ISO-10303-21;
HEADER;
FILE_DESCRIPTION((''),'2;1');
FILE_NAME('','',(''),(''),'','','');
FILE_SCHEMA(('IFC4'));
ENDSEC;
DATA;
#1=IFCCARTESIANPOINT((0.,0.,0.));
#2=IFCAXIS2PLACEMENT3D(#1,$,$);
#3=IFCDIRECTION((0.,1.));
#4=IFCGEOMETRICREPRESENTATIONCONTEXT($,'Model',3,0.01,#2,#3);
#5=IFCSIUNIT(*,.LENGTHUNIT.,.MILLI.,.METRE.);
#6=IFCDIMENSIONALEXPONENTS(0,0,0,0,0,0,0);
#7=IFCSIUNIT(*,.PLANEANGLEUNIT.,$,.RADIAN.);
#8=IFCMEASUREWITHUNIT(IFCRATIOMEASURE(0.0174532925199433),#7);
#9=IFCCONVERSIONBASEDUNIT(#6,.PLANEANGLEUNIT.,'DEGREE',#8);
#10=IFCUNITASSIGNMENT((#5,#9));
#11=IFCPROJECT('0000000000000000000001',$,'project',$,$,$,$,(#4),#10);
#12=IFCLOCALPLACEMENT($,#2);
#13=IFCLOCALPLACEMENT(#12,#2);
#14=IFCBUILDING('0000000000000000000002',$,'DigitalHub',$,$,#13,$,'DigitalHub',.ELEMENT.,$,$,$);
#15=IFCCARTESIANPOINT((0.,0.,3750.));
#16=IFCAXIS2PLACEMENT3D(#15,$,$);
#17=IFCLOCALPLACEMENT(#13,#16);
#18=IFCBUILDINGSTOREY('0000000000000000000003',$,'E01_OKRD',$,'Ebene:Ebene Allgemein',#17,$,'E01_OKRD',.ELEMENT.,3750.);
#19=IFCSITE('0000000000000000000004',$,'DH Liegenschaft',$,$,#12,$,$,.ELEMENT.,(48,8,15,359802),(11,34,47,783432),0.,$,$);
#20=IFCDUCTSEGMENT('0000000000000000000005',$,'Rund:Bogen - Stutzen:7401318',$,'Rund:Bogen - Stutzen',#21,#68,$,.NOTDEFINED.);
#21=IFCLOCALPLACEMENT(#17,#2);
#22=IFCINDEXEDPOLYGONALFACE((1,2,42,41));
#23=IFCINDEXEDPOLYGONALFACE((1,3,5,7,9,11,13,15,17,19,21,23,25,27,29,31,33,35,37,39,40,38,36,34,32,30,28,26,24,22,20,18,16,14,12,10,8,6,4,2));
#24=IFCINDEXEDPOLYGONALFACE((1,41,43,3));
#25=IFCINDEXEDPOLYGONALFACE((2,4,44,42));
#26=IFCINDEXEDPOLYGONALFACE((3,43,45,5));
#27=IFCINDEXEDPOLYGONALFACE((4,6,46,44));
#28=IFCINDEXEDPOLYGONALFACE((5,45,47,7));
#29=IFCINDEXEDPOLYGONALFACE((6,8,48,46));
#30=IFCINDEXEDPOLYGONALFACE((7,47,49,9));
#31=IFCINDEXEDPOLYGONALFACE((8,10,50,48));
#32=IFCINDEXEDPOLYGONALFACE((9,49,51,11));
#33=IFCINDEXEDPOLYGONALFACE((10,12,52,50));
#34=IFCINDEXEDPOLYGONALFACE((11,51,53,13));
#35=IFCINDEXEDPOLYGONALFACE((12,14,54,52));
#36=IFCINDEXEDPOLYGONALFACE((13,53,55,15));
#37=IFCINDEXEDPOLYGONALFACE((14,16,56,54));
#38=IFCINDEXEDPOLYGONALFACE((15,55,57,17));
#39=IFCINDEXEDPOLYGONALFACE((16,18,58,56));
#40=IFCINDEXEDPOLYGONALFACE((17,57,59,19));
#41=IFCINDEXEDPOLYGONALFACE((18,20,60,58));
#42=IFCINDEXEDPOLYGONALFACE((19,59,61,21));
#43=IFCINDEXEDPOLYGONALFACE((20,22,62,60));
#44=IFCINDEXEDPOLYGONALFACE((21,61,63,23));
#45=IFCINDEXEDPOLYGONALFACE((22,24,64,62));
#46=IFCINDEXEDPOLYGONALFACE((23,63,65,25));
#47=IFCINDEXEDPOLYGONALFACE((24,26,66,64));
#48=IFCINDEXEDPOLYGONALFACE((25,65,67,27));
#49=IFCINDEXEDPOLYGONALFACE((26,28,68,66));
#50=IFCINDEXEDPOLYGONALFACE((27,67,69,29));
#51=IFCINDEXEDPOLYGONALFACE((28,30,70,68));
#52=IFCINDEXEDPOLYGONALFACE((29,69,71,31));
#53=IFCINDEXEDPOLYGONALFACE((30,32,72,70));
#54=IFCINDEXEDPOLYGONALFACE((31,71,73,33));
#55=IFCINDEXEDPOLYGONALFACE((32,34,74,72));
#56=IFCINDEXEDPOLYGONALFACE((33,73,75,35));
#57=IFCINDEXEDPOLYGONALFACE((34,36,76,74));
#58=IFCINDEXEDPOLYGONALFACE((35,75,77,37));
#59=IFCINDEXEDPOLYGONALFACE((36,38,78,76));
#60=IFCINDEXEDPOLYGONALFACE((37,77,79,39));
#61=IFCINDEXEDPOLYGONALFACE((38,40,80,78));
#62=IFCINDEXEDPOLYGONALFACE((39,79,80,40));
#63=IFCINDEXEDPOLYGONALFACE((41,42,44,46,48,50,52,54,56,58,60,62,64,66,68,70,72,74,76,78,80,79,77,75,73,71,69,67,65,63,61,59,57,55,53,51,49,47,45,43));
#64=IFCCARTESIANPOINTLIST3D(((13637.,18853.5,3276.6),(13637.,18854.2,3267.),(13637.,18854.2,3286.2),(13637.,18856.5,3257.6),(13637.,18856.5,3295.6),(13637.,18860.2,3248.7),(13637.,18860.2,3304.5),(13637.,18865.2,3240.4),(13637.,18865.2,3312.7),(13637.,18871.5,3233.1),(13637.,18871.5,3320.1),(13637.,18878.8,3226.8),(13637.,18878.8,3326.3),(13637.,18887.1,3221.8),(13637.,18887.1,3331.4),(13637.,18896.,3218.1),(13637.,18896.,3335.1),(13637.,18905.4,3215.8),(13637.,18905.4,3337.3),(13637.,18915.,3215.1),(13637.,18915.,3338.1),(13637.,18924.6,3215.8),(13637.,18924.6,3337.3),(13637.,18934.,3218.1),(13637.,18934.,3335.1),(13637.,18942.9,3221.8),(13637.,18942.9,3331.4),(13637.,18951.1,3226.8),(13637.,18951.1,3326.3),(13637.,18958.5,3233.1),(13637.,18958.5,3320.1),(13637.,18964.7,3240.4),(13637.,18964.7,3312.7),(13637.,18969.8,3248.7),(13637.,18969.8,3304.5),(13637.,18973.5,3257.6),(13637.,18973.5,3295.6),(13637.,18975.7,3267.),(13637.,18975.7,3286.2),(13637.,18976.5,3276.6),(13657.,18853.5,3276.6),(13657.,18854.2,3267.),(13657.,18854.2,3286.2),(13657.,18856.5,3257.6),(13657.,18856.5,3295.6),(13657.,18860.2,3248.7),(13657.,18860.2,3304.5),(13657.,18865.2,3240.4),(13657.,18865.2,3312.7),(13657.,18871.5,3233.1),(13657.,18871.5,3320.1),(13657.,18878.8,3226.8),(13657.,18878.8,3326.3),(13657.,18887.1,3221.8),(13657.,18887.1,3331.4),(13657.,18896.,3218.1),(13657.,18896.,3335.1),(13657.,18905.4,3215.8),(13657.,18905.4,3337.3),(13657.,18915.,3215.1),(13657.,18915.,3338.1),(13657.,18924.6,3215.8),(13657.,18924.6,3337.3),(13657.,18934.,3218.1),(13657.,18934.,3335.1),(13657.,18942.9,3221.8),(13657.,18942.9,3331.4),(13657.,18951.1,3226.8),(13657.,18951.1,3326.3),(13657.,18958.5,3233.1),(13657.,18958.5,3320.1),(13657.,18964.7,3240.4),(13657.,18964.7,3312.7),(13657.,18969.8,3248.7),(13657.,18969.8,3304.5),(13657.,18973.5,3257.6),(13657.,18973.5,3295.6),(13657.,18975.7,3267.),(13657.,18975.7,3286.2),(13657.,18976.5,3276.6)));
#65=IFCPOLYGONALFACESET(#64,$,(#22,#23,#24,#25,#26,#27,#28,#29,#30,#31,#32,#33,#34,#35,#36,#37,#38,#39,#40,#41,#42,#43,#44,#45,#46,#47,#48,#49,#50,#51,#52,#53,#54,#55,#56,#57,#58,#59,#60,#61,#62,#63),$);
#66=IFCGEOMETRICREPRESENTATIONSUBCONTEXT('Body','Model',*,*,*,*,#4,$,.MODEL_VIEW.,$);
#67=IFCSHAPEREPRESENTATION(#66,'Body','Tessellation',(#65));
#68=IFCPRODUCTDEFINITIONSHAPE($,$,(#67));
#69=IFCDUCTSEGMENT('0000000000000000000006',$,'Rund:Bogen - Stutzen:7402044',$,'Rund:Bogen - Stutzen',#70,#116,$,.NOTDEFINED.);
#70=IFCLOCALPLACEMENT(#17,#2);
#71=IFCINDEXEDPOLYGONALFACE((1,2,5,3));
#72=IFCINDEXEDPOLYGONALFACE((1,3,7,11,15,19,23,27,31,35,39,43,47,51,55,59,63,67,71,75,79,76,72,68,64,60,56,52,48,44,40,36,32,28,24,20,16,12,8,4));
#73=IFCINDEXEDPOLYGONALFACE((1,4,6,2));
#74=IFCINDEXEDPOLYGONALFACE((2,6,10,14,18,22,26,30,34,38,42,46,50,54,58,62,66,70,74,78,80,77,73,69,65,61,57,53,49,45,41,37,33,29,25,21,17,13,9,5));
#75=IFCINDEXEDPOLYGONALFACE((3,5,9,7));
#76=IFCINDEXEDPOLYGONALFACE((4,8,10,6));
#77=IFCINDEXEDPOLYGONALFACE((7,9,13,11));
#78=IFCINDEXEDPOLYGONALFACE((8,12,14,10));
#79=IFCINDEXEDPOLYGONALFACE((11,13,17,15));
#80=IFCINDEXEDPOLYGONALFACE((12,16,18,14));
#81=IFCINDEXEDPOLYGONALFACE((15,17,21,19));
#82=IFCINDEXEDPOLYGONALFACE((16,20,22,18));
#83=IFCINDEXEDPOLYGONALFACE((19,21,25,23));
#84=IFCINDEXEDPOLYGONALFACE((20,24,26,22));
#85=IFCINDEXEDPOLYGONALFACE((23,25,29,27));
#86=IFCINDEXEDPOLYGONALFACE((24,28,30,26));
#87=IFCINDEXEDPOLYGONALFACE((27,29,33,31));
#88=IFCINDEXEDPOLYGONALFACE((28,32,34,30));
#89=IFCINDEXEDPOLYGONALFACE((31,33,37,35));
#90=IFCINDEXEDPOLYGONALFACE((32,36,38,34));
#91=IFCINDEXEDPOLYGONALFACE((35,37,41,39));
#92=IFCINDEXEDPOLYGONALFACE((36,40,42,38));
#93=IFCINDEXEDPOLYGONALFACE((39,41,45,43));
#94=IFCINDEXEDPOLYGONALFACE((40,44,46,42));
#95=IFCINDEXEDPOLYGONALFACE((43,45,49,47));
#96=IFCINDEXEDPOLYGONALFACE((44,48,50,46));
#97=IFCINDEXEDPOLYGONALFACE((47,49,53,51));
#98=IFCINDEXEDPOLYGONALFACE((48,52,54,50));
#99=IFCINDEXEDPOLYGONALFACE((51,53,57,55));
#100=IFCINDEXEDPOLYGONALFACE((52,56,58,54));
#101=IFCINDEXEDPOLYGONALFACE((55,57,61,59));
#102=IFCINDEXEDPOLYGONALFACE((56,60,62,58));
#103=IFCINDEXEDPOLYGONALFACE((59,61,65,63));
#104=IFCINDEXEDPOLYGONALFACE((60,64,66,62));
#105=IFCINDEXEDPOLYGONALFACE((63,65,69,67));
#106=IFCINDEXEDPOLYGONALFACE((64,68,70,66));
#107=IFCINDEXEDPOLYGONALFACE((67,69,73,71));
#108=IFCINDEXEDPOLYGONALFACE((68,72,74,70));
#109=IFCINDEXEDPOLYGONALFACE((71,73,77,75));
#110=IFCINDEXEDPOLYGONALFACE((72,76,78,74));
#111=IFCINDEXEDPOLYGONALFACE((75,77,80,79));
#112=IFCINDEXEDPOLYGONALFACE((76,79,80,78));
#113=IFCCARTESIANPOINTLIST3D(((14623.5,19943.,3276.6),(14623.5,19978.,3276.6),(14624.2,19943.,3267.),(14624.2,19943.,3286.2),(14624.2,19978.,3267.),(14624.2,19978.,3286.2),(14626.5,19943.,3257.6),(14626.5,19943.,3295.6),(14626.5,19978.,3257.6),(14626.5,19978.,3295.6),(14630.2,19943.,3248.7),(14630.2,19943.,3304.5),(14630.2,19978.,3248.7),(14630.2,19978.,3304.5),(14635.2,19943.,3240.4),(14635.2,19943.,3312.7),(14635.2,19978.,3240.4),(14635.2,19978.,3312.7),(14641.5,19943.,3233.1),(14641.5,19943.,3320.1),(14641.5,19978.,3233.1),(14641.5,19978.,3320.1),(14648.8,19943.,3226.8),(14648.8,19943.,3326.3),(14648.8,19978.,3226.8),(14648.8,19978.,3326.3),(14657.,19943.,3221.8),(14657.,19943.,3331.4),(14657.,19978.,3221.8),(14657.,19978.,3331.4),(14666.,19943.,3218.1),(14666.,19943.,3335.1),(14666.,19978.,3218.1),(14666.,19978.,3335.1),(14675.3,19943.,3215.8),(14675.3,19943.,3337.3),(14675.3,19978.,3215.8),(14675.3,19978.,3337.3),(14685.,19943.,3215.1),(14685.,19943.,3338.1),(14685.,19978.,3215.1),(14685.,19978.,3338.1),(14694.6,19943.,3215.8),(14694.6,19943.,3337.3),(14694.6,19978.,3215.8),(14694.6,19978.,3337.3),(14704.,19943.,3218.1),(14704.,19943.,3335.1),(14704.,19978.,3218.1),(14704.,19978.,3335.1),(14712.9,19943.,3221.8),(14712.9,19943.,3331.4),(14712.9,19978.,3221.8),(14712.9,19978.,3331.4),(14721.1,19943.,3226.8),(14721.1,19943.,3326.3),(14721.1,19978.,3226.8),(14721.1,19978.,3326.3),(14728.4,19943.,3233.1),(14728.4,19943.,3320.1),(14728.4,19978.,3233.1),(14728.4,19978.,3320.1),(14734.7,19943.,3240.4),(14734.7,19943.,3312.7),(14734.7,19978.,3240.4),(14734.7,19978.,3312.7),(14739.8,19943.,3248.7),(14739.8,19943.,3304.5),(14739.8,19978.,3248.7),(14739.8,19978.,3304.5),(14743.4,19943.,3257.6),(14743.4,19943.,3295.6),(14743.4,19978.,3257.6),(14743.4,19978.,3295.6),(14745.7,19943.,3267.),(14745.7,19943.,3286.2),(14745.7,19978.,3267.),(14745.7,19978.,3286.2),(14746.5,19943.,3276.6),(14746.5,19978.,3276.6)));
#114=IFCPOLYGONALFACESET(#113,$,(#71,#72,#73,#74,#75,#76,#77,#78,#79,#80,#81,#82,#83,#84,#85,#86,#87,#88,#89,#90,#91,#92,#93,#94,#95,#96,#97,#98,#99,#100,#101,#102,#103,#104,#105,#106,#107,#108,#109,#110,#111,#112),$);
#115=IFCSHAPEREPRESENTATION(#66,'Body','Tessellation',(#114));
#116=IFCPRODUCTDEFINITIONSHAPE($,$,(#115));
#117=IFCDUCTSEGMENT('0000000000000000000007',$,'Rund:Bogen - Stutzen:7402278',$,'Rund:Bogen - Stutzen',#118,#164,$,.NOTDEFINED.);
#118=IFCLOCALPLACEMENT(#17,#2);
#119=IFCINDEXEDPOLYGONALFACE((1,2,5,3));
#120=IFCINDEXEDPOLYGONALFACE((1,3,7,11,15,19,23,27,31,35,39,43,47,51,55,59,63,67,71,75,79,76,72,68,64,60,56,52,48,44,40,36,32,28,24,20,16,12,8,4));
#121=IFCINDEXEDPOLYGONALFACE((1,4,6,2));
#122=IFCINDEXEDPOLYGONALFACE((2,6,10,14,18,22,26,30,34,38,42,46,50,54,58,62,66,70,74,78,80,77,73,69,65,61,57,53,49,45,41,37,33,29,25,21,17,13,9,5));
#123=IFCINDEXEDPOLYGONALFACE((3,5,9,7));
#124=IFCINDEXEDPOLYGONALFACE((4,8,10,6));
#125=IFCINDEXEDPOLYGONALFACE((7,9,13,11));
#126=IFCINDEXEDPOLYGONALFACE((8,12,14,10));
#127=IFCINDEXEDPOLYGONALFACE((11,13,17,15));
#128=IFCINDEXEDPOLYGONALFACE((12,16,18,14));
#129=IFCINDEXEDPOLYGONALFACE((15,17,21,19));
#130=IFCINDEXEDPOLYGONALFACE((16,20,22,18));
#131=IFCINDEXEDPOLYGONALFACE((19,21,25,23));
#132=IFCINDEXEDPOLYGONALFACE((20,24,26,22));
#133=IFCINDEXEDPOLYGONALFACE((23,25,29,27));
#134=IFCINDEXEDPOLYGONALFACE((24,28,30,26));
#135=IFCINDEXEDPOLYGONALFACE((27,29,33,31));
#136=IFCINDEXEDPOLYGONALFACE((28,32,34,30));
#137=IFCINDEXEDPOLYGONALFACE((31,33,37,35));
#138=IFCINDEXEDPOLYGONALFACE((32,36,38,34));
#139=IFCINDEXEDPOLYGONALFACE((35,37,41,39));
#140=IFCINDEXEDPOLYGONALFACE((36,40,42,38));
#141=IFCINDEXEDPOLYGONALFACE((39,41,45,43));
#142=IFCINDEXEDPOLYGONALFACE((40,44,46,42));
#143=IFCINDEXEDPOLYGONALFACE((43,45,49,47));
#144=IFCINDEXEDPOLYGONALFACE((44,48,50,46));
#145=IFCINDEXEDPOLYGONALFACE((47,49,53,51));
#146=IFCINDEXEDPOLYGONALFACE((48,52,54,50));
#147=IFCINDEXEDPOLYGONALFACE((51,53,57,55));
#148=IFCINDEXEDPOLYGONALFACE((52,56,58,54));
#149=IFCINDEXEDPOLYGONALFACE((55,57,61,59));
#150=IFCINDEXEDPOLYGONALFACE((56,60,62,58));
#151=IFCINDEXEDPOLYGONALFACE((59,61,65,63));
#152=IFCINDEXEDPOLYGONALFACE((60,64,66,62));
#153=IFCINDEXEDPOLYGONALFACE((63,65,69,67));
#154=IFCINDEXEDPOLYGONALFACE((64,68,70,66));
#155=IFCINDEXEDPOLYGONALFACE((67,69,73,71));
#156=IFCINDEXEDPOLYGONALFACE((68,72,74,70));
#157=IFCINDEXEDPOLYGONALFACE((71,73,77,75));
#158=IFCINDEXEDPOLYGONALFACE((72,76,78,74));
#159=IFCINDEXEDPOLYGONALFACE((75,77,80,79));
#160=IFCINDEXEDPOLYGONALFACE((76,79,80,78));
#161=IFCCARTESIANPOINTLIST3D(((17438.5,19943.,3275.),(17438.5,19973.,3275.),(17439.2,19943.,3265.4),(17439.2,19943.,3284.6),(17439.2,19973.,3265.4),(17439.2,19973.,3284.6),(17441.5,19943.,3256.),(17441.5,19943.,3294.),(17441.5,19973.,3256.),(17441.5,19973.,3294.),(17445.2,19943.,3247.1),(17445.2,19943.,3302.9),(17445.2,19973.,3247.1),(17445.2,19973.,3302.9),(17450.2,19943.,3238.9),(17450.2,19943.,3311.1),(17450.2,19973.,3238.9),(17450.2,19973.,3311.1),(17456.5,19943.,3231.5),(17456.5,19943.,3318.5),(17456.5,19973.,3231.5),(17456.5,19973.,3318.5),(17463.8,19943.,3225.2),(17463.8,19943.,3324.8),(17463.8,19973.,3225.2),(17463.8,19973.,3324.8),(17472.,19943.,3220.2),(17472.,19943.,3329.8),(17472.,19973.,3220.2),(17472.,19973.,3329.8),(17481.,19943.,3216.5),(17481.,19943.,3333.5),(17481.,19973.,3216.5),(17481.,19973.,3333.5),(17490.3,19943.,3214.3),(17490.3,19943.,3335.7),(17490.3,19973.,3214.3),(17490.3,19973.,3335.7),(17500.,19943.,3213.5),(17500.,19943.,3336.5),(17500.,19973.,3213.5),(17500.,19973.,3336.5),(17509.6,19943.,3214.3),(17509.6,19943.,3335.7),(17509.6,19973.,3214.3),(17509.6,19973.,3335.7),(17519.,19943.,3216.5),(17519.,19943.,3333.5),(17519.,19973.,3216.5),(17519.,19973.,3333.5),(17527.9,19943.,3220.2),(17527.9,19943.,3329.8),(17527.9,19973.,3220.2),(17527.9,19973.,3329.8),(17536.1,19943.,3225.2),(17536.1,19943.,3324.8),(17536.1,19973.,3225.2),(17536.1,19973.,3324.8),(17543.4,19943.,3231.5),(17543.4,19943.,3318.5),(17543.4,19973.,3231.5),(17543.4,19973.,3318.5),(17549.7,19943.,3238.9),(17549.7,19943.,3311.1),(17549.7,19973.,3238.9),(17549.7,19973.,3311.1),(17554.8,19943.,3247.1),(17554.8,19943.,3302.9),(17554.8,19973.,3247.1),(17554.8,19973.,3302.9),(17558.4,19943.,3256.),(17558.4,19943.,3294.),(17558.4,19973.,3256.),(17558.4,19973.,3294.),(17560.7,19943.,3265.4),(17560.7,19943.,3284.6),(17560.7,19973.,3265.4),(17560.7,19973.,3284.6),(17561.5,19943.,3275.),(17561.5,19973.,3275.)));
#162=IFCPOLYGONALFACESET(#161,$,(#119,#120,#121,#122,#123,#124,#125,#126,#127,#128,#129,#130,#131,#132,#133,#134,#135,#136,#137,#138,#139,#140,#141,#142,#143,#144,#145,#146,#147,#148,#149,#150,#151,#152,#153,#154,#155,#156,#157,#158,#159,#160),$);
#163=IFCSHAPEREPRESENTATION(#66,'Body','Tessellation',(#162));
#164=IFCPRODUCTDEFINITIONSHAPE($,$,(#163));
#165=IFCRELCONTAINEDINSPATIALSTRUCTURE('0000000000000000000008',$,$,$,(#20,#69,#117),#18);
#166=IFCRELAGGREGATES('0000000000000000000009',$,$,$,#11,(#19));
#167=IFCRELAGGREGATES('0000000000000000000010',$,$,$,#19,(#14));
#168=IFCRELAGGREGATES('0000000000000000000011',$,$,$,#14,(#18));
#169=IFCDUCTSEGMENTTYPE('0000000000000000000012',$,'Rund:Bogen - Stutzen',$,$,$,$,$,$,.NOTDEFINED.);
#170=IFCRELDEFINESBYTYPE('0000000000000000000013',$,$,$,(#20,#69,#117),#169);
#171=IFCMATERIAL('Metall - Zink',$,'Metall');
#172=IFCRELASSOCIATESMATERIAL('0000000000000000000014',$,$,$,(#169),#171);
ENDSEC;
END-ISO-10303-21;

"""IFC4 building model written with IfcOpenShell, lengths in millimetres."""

from ifc_helpers import new_model, entity, si_unit, converted_unit, direction, frame, origin, place, context, subcontext, project, spatial, indexed_curve, outline, extrude, material, type_object, element, save


model = new_model("IFC4")

# Units and contexts
model_context = context("Model", 3, precision=0.01, world=origin(), true_north=direction((0.0, 1.0)))
body_context = subcontext(model_context, "Body", "Model", "MODEL_VIEW")
ifc_project = project(units=[si_unit("LENGTHUNIT", "METRE", prefix="MILLI"), converted_unit("PLANEANGLEUNIT", "DEGREE", entity("IfcRatioMeasure", 0.0174532925199433), si_unit("PLANEANGLEUNIT", "RADIAN"), dimensions=[0, 0, 0, 0, 0, 0, 0])], contexts=[model_context])

# Site, building, storey
site_placement = place(None, origin())
site = spatial("IfcSite", under=ifc_project, at=site_placement, Name="DH Liegenschaft", CompositionType="ELEMENT", RefLatitude=(48, 8, 15, 359802), RefLongitude=(11, 34, 47, 783432), RefElevation=0.0)
building_placement = place(site_placement, origin())
building = spatial("IfcBuilding", under=site, at=building_placement, Name="DigitalHub", LongName="DigitalHub", CompositionType="ELEMENT")
storey_placement = place(building_placement, frame((0.0, 0.0, 3750.0)))
storey = spatial("IfcBuildingStorey", under=building, at=storey_placement, Name="E01_OKRD", ObjectType="Ebene:Ebene Allgemein", LongName="E01_OKRD", CompositionType="ELEMENT", Elevation=3750.0)

# Shared definitions
ifc_material_1 = material(Name="Metall - Zink", Category="Metall")

# Duct segments
duct_segment_type_1 = type_object("IfcDuctSegmentType", Name="Rund:Bogen - Stutzen", PredefinedType="NOTDEFINED", material=ifc_material_1)
duct_segment_1_placement = place(storey_placement, frame((13637.0, 18851.9, 3213.5)))
element("IfcDuctSegment", 1, at=duct_segment_1_placement, inside=storey, type_object=duct_segment_type_1, Name="Rund:Bogen - Stutzen:7401318", ObjectType="Rund:Bogen - Stutzen", PredefinedType="NOTDEFINED", context=body_context, shape_type="SweptSolid", body=[
    extrude(outline(indexed_curve([(61.5, 0.0), (60.7, 9.6), (58.5, 19.0), (54.8, 27.9), (49.8, 36.1), (43.5, 43.5), (36.1, 49.8), (27.9, 54.8), (19.0, 58.5), (9.6, 60.7), (0.0, 61.5), (-9.6, 60.7), (-19.0, 58.5), (-27.9, 54.8), (-36.1, 49.8), (-43.5, 43.5), (-49.8, 36.1), (-54.8, 27.9), (-58.5, 19.0), (-60.7, 9.6), (-61.5, 0.0), (-60.7, -9.6), (-58.5, -19.0), (-54.8, -27.9), (-49.8, -36.1), (-43.5, -43.5), (-36.1, -49.8), (-27.9, -54.8), (-19.0, -58.5), (-9.6, -60.7), (0.0, -61.5), (9.6, -60.7), (19.0, -58.5), (27.9, -54.8), (36.1, -49.8), (43.5, -43.5), (49.8, -36.1), (54.8, -27.9), (58.5, -19.0), (60.7, -9.6), (61.5, 0.0)], self_intersect=False)), frame((0.0, 63.1, 63.1), z_axis=(1.0, 0.0, 0.0), x_axis=(0.0, 1.0, 0.0)), (0.0, 0.0, 1.0), 20.0),
])
duct_segment_2_placement = place(storey_placement, frame((14621.9, 19943.0, 3213.5)))
element("IfcDuctSegment", 2, at=duct_segment_2_placement, inside=storey, type_object=duct_segment_type_1, Name="Rund:Bogen - Stutzen:7402044", ObjectType="Rund:Bogen - Stutzen", PredefinedType="NOTDEFINED", context=body_context, shape_type="SweptSolid", body=[
    extrude(outline(indexed_curve([(61.5, 0.0), (60.7, 9.6), (58.5, 19.0), (54.8, 27.9), (49.8, 36.1), (43.5, 43.5), (36.1, 49.8), (27.9, 54.8), (19.0, 58.5), (9.6, 60.7), (0.0, 61.5), (-9.6, 60.7), (-19.0, 58.5), (-27.9, 54.8), (-36.1, 49.8), (-43.5, 43.5), (-49.8, 36.1), (-54.8, 27.9), (-58.5, 19.0), (-60.7, 9.6), (-61.5, 0.0), (-60.7, -9.6), (-58.5, -19.0), (-54.8, -27.9), (-49.8, -36.1), (-43.5, -43.5), (-36.1, -49.8), (-27.9, -54.8), (-19.0, -58.5), (-9.6, -60.7), (0.0, -61.5), (9.6, -60.7), (19.0, -58.5), (27.9, -54.8), (36.1, -49.8), (43.5, -43.5), (49.8, -36.1), (54.8, -27.9), (58.5, -19.0), (60.7, -9.6), (61.5, 0.0)], self_intersect=False)), frame((63.1, 0.0, 63.1), z_axis=(0.0, 1.0, 0.0), x_axis=(1.0, 0.0, 0.0)), (0.0, 0.0, 1.0), 35.0),
])
duct_segment_3_placement = place(storey_placement, frame((17436.9, 19943.0, 3211.9)))
element("IfcDuctSegment", 3, at=duct_segment_3_placement, inside=storey, type_object=duct_segment_type_1, Name="Rund:Bogen - Stutzen:7402278", ObjectType="Rund:Bogen - Stutzen", PredefinedType="NOTDEFINED", context=body_context, shape_type="SweptSolid", body=[
    extrude(outline(indexed_curve([(61.5, 0.0), (60.7, 9.6), (58.5, 19.0), (54.8, 27.9), (49.8, 36.1), (43.5, 43.5), (36.1, 49.8), (27.9, 54.8), (19.0, 58.5), (9.6, 60.7), (0.0, 61.5), (-9.6, 60.7), (-19.0, 58.5), (-27.9, 54.8), (-36.1, 49.8), (-43.5, 43.5), (-49.8, 36.1), (-54.8, 27.9), (-58.5, 19.0), (-60.7, 9.6), (-61.5, 0.0), (-60.7, -9.6), (-58.5, -19.0), (-54.8, -27.9), (-49.8, -36.1), (-43.5, -43.5), (-36.1, -49.8), (-27.9, -54.8), (-19.0, -58.5), (-9.6, -60.7), (0.0, -61.5), (9.6, -60.7), (19.0, -58.5), (27.9, -54.8), (36.1, -49.8), (43.5, -43.5), (49.8, -36.1), (54.8, -27.9), (58.5, -19.0), (60.7, -9.6), (61.5, 0.0)], self_intersect=False)), frame((63.1, 0.0, 63.1), z_axis=(0.0, 1.0, 0.0), x_axis=(1.0, 0.0, 0.0)), (0.0, 0.0, 1.0), 30.0),
])

save(model, "model.ifc")
